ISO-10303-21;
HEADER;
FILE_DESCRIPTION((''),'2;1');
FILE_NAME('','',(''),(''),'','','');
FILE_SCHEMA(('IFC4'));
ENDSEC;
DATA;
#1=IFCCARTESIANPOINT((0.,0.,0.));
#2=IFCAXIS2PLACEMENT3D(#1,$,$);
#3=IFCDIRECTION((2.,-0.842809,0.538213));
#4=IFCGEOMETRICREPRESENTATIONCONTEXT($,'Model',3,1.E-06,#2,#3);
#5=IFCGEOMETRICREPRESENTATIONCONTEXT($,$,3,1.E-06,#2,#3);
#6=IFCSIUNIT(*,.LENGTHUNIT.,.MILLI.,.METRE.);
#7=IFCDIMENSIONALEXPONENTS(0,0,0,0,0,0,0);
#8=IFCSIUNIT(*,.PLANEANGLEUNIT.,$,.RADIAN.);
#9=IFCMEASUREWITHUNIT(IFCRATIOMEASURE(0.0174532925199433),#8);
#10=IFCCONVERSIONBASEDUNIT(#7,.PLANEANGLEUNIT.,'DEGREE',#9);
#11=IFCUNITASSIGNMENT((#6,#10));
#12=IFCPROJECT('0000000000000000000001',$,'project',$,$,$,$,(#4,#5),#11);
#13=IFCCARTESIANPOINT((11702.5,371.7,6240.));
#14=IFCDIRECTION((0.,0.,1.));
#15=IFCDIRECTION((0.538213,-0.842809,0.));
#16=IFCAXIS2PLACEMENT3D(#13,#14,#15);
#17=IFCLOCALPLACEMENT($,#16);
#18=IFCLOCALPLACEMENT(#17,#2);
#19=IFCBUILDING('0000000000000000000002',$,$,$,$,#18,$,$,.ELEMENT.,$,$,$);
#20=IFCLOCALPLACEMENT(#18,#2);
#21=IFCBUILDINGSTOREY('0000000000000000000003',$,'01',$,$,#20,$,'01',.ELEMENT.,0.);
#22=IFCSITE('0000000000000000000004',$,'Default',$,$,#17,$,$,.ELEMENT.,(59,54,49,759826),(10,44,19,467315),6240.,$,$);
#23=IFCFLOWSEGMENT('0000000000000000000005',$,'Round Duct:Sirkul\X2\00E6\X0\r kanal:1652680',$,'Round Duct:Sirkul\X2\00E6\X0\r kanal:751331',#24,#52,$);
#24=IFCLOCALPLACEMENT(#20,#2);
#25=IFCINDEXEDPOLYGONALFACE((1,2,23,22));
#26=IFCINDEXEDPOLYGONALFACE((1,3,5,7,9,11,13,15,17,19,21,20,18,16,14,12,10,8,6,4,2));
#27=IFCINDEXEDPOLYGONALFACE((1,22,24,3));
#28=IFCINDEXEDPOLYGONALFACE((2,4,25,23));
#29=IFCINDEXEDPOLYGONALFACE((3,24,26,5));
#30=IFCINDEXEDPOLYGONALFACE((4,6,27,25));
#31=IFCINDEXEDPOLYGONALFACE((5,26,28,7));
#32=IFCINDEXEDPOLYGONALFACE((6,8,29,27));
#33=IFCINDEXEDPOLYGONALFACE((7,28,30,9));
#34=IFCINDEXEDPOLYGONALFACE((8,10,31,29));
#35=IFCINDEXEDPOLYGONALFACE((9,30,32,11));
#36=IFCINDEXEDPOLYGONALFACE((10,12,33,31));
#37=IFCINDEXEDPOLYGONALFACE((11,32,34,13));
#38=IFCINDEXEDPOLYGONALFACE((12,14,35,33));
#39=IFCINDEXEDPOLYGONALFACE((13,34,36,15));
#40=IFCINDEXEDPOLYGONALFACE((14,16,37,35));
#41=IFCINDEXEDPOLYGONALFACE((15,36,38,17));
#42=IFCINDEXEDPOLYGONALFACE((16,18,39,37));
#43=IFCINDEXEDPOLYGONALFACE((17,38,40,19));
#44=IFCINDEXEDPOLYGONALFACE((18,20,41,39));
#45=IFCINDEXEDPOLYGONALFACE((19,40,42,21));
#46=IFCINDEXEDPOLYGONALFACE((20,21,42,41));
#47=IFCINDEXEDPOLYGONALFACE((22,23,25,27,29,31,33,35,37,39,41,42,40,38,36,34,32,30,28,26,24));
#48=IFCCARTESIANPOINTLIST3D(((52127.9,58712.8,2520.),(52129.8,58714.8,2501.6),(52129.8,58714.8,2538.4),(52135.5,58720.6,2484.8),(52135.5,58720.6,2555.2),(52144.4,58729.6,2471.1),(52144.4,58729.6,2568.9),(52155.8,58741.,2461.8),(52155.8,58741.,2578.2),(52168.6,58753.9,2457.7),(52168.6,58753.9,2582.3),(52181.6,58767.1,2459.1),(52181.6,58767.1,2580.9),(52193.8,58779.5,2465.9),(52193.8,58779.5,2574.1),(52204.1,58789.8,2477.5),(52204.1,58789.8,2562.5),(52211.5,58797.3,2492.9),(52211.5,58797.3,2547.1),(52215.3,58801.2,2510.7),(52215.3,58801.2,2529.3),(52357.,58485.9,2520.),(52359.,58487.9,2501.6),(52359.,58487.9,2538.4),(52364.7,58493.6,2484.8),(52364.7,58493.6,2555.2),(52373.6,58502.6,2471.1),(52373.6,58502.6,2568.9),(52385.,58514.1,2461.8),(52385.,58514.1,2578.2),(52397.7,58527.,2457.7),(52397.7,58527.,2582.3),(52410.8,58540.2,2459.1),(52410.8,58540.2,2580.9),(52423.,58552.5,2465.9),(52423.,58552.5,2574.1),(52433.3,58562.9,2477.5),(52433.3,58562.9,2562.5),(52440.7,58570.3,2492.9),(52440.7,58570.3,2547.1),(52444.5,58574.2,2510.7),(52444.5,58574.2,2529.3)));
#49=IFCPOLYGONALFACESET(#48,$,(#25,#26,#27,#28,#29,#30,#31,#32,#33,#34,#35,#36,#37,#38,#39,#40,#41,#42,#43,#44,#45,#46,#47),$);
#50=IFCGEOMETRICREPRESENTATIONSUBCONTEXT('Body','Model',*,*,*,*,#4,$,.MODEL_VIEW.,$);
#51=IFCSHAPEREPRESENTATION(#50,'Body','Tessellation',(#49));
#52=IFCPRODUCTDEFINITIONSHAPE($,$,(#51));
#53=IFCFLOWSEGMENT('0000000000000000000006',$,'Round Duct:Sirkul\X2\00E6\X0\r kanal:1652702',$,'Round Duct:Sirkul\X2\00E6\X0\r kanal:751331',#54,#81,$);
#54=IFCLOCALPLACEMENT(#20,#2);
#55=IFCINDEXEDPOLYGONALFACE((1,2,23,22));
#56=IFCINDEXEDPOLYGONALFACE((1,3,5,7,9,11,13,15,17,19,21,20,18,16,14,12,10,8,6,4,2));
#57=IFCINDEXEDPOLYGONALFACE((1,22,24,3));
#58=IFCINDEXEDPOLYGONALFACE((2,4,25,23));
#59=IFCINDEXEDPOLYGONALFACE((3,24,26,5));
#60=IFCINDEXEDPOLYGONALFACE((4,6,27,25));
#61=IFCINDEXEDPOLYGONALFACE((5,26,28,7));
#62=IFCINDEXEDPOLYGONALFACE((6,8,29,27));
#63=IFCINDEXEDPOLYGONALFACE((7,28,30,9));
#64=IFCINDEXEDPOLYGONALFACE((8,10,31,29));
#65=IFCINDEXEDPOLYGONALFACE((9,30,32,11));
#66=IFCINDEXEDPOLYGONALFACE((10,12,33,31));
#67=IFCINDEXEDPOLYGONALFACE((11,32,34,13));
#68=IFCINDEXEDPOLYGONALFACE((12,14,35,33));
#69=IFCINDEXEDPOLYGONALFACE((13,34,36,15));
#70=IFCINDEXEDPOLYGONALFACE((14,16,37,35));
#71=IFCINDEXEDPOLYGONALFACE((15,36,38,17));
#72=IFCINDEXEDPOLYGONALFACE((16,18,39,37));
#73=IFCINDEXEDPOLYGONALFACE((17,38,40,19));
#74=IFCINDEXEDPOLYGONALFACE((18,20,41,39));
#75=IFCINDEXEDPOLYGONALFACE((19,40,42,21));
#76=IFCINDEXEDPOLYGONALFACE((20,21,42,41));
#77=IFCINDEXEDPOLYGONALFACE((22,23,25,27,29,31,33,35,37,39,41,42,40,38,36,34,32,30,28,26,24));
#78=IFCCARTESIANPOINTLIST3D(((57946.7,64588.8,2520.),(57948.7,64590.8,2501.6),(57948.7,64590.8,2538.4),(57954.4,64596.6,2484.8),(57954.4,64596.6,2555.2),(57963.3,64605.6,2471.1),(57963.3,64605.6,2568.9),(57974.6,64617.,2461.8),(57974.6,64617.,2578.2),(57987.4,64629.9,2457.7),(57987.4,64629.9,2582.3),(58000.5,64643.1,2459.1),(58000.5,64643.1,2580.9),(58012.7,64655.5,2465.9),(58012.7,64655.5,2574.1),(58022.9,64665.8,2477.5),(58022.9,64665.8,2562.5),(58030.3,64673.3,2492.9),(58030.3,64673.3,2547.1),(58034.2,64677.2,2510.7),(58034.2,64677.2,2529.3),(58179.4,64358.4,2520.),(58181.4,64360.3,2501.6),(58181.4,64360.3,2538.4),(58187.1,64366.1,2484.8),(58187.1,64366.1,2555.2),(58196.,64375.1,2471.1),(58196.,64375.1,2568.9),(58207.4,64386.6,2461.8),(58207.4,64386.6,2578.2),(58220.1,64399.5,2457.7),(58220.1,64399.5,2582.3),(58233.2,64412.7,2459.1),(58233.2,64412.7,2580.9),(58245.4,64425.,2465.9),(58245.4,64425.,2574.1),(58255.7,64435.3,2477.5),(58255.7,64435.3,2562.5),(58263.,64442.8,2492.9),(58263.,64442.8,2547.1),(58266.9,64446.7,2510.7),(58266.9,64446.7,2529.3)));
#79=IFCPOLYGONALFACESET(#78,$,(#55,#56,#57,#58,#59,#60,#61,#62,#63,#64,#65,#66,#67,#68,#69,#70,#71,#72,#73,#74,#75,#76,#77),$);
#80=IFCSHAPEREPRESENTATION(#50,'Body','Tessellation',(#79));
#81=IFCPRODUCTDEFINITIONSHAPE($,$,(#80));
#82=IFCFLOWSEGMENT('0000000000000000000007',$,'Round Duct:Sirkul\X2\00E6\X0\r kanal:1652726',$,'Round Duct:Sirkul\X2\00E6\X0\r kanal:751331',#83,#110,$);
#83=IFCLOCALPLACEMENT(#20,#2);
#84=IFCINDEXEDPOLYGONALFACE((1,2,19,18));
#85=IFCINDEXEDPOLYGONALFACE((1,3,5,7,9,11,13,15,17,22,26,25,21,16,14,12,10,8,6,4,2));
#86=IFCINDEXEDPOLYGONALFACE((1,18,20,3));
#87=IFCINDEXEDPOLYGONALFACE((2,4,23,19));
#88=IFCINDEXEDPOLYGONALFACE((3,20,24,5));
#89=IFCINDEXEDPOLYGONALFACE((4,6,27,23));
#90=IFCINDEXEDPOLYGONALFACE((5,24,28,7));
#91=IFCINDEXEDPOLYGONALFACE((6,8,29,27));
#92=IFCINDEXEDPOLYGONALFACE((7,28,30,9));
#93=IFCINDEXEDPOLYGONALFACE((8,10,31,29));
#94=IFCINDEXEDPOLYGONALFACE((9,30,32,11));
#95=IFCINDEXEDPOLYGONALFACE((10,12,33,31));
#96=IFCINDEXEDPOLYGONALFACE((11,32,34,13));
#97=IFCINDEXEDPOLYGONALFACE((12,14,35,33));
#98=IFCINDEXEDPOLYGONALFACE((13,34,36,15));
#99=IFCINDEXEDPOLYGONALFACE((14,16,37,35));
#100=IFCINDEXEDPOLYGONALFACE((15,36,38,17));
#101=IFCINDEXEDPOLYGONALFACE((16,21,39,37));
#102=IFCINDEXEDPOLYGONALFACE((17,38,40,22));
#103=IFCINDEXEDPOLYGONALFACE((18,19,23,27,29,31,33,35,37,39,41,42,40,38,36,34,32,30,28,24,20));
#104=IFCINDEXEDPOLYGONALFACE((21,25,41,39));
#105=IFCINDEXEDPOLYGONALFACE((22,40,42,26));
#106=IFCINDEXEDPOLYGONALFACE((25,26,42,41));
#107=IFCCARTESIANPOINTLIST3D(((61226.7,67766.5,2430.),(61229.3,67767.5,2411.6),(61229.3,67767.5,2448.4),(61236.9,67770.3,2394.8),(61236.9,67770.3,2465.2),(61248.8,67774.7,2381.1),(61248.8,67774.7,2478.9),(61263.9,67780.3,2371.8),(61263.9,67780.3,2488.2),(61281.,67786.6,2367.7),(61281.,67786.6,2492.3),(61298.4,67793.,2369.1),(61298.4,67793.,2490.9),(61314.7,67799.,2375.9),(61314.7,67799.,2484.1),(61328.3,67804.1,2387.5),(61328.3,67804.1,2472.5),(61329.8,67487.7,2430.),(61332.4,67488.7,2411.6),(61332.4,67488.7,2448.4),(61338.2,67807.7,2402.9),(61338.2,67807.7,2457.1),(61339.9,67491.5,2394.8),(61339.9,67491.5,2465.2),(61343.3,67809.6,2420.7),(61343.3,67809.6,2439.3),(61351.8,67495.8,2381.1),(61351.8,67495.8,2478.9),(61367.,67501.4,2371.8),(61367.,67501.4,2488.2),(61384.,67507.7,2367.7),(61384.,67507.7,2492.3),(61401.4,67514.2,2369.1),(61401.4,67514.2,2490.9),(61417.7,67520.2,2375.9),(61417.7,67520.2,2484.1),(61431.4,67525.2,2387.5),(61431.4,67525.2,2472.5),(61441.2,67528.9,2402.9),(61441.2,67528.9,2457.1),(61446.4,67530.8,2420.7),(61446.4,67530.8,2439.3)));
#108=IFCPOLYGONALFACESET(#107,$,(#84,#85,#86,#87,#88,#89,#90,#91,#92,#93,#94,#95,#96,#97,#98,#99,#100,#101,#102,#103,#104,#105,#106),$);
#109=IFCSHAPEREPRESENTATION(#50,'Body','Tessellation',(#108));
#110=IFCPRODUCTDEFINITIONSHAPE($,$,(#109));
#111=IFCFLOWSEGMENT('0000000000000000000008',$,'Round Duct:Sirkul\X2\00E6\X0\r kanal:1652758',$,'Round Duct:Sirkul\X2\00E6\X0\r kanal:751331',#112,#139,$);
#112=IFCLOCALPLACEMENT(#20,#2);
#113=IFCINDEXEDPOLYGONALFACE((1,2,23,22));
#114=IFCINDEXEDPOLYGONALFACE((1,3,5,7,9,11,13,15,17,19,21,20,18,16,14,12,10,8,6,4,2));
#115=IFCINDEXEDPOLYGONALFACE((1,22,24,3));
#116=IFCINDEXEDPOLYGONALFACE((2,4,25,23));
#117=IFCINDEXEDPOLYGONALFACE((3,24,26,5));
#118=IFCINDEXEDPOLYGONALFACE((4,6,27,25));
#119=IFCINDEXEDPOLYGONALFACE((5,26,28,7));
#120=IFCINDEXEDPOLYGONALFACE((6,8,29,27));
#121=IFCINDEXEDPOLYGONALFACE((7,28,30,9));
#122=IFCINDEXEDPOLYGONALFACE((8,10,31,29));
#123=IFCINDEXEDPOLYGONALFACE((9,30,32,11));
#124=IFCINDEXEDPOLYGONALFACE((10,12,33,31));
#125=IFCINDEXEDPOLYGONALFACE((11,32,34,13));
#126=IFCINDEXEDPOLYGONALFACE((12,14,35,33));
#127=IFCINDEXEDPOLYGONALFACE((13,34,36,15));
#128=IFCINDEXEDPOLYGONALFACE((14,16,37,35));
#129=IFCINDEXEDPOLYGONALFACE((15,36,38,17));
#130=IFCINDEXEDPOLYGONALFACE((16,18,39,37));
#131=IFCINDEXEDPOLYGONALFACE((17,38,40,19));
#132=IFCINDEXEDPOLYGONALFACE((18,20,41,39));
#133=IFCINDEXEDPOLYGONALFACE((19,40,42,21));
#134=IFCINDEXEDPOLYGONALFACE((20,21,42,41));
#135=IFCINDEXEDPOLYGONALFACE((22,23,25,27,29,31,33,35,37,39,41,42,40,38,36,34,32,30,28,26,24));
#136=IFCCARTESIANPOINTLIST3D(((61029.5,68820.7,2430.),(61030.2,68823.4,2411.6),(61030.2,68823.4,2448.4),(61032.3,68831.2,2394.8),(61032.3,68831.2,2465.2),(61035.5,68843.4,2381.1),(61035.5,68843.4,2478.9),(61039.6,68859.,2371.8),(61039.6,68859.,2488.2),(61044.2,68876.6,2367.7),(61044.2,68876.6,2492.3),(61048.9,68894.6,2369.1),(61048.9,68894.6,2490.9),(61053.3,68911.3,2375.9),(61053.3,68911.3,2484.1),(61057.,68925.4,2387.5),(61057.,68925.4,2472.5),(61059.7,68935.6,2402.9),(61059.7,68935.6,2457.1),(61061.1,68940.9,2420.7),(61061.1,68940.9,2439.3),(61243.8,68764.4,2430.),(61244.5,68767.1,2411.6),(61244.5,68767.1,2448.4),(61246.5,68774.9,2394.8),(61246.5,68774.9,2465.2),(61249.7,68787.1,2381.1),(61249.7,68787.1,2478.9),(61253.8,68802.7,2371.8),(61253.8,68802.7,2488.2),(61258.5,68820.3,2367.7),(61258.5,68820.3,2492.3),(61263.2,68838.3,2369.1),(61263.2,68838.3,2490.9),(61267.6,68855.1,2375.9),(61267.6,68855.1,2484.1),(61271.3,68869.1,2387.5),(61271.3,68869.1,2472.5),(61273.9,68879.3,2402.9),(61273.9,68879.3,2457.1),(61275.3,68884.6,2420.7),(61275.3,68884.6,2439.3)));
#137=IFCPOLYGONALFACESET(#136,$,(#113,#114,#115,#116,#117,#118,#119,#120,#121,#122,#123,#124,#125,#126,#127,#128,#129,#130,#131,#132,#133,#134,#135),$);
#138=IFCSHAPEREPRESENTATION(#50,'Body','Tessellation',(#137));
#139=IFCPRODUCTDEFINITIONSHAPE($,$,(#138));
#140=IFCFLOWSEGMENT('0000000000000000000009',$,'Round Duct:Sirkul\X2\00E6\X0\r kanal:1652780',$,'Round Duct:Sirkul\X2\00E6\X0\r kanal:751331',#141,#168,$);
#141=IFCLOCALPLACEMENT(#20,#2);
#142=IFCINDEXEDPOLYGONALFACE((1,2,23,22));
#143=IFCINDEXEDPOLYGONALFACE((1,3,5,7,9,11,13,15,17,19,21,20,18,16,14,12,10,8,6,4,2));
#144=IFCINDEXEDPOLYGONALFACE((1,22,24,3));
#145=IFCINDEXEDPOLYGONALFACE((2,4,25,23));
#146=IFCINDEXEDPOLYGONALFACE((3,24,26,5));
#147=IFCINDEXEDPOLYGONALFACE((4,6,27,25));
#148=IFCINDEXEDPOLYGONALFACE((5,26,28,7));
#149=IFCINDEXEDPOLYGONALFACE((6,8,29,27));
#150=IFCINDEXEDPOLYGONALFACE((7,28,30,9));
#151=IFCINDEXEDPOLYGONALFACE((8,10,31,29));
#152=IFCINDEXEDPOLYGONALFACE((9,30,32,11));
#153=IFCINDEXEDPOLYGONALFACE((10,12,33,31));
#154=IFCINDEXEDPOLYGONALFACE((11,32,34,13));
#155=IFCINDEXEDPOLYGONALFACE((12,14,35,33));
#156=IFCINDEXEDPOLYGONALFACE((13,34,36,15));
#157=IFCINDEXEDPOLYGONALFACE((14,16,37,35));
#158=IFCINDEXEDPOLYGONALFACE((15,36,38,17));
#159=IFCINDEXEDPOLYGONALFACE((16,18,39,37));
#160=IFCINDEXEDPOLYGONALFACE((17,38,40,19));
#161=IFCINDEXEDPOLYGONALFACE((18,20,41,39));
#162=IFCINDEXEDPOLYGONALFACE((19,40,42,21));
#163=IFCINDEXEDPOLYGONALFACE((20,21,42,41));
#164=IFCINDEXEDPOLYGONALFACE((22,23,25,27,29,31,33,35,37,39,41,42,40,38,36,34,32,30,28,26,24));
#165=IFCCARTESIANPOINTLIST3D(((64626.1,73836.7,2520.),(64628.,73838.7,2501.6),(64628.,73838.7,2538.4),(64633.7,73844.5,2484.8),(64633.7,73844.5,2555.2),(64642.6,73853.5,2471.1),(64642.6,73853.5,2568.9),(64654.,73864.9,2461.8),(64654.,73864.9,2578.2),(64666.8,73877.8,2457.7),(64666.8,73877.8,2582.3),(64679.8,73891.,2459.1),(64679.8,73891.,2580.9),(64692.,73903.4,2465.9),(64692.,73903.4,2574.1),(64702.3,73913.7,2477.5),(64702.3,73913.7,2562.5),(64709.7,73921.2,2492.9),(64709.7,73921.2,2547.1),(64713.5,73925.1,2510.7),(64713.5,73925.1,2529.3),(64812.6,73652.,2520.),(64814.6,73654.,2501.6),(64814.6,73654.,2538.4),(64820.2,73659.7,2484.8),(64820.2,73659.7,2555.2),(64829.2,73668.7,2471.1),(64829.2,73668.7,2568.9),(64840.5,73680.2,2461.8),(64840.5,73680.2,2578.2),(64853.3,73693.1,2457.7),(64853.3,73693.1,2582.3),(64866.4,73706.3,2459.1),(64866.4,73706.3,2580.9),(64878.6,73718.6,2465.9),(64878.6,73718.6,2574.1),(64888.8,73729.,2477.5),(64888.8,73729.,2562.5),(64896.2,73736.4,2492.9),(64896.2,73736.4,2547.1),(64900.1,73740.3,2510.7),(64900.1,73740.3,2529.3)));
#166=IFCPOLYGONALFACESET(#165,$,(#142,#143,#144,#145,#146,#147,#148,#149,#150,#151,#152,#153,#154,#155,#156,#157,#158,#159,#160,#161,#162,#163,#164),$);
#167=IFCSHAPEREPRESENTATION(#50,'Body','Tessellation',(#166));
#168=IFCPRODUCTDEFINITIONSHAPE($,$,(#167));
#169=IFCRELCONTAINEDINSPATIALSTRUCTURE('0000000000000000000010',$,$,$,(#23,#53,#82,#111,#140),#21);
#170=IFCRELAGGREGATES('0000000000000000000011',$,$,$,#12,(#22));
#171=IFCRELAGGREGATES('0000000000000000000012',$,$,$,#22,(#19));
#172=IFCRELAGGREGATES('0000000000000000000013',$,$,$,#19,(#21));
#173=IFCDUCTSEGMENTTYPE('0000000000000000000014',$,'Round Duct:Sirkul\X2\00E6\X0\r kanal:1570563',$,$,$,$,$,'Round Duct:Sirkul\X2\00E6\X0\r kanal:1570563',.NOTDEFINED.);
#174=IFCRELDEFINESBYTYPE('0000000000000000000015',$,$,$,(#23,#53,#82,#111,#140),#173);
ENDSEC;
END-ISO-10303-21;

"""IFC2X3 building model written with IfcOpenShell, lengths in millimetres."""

from ifc_helpers import new_model, entity, si_unit, converted_unit, direction, frame, frame_2d, origin, origin_2d_with_axis, place, context, subcontext, project, spatial, circle, extrude, type_object, element, save


model = new_model("IFC2X3")

# Units and contexts
model_context = context("Model", 3, precision=1e-06, world=origin(), true_north=direction((2.0, -0.842809, 0.538213)))
context_of_model = context(None, 3, precision=1e-06, world=origin(), true_north=direction((2.0, -0.842809, 0.538213)))
body_context = subcontext(model_context, "Body", "Model", "MODEL_VIEW")
ifc_project = project(units=[si_unit("LENGTHUNIT", "METRE", prefix="MILLI"), converted_unit("PLANEANGLEUNIT", "DEGREE", entity("IfcRatioMeasure", 0.0174532925199433), si_unit("PLANEANGLEUNIT", "RADIAN"), dimensions=[0, 0, 0, 0, 0, 0, 0])], contexts=[model_context, context_of_model])

# Site, building, storey
site_placement = place(None, frame((11702.5, 371.7, 6240.0), z_axis=(0.0, 0.0, 1.0), x_axis=(0.538213, -0.842809, 0.0)))
site = spatial("IfcSite", under=ifc_project, at=site_placement, Name="Default", CompositionType="ELEMENT", RefLatitude=(59, 54, 49, 759826), RefLongitude=(10, 44, 19, 467315), RefElevation=6240.0)
building_placement = place(site_placement, origin())
building = spatial("IfcBuilding", under=site, at=building_placement, CompositionType="ELEMENT")
storey_placement = place(building_placement, origin())
storey = spatial("IfcBuildingStorey", under=building, at=storey_placement, Name="01", LongName="01", CompositionType="ELEMENT", Elevation=0.0)

# Flow segments
duct_segment_type = type_object("IfcDuctSegmentType", Name="Round Duct:Sirkulær kanal:1570563", ElementType="Round Duct:Sirkulær kanal:1570563", PredefinedType="NOTDEFINED")
flow_segment_1_placement = place(storey_placement, origin())
element("IfcFlowSegment", 1, at=flow_segment_1_placement, inside=storey, type_object=duct_segment_type, Name="Round Duct:Sirkulær kanal:1652680", ObjectType="Round Duct:Sirkulær kanal:751331", context=body_context, shape_type="SweptSolid", body=[
    extrude(circle(Radius=62.5, at=origin_2d_with_axis()), frame((52171.9, 58757.3, 2520.0), z_axis=(0.710554, -0.703643, 0.0), x_axis=(-0.703643, -0.710554, 0.0)), (0.0, 0.0, 1.0), 322.5),
])
flow_segment_2_placement = place(storey_placement, origin())
element("IfcFlowSegment", 2, at=flow_segment_2_placement, inside=storey, type_object=duct_segment_type, Name="Round Duct:Sirkulær kanal:1652702", ObjectType="Round Duct:Sirkulær kanal:751331", context=body_context, shape_type="SweptSolid", body=[
    extrude(circle(Radius=62.5, at=origin_2d_with_axis()), frame((58223.4, 64402.8, 2520.0), z_axis=(-0.710554, 0.703643, 0.0), x_axis=(-0.703643, -0.710554, 0.0)), (0.0, 0.0, 1.0), 327.5),
])
flow_segment_3_placement = place(storey_placement, origin())
element("IfcFlowSegment", 3, at=flow_segment_3_placement, inside=storey, type_object=duct_segment_type, Name="Round Duct:Sirkulær kanal:1652726", ObjectType="Round Duct:Sirkulær kanal:751331", context=body_context, shape_type="SweptSolid", body=[
    extrude(circle(Radius=62.5, at=frame_2d((0.0, 0.0), x_axis=(1.0, 0.0))), frame((61285.3, 67788.2, 2430.0), z_axis=(0.346608, -0.93801, 0.0), x_axis=(-0.93801, -0.346608, 0.0)), (0.0, 0.0, 1.0), 297.3),
])
flow_segment_4_placement = place(storey_placement, origin())
element("IfcFlowSegment", 4, at=flow_segment_4_placement, inside=storey, type_object=duct_segment_type, Name="Round Duct:Sirkulær kanal:1652758", ObjectType="Round Duct:Sirkulær kanal:751331", context=body_context, shape_type="SweptSolid", body=[
    extrude(circle(Radius=62.5, at=frame_2d((0.0, 0.0), x_axis=(1.0, 0.0))), frame((61045.4, 68881.1, 2430.0), z_axis=(0.967179, -0.254096, 0.0), x_axis=(-0.254096, -0.967179, 0.0)), (0.0, 0.0, 1.0), 221.5),
])
flow_segment_5_placement = place(storey_placement, origin())
element("IfcFlowSegment", 5, at=flow_segment_5_placement, inside=storey, type_object=duct_segment_type, Name="Round Duct:Sirkulær kanal:1652780", ObjectType="Round Duct:Sirkulær kanal:751331", context=body_context, shape_type="SweptSolid", body=[
    extrude(circle(Radius=62.5, at=origin_2d_with_axis()), frame((64856.6, 73696.4, 2520.0), z_axis=(-0.710554, 0.703643, 0.0), x_axis=(-0.703643, -0.710554, 0.0)), (0.0, 0.0, 1.0), 262.5),
])

save(model, "model.ifc")
